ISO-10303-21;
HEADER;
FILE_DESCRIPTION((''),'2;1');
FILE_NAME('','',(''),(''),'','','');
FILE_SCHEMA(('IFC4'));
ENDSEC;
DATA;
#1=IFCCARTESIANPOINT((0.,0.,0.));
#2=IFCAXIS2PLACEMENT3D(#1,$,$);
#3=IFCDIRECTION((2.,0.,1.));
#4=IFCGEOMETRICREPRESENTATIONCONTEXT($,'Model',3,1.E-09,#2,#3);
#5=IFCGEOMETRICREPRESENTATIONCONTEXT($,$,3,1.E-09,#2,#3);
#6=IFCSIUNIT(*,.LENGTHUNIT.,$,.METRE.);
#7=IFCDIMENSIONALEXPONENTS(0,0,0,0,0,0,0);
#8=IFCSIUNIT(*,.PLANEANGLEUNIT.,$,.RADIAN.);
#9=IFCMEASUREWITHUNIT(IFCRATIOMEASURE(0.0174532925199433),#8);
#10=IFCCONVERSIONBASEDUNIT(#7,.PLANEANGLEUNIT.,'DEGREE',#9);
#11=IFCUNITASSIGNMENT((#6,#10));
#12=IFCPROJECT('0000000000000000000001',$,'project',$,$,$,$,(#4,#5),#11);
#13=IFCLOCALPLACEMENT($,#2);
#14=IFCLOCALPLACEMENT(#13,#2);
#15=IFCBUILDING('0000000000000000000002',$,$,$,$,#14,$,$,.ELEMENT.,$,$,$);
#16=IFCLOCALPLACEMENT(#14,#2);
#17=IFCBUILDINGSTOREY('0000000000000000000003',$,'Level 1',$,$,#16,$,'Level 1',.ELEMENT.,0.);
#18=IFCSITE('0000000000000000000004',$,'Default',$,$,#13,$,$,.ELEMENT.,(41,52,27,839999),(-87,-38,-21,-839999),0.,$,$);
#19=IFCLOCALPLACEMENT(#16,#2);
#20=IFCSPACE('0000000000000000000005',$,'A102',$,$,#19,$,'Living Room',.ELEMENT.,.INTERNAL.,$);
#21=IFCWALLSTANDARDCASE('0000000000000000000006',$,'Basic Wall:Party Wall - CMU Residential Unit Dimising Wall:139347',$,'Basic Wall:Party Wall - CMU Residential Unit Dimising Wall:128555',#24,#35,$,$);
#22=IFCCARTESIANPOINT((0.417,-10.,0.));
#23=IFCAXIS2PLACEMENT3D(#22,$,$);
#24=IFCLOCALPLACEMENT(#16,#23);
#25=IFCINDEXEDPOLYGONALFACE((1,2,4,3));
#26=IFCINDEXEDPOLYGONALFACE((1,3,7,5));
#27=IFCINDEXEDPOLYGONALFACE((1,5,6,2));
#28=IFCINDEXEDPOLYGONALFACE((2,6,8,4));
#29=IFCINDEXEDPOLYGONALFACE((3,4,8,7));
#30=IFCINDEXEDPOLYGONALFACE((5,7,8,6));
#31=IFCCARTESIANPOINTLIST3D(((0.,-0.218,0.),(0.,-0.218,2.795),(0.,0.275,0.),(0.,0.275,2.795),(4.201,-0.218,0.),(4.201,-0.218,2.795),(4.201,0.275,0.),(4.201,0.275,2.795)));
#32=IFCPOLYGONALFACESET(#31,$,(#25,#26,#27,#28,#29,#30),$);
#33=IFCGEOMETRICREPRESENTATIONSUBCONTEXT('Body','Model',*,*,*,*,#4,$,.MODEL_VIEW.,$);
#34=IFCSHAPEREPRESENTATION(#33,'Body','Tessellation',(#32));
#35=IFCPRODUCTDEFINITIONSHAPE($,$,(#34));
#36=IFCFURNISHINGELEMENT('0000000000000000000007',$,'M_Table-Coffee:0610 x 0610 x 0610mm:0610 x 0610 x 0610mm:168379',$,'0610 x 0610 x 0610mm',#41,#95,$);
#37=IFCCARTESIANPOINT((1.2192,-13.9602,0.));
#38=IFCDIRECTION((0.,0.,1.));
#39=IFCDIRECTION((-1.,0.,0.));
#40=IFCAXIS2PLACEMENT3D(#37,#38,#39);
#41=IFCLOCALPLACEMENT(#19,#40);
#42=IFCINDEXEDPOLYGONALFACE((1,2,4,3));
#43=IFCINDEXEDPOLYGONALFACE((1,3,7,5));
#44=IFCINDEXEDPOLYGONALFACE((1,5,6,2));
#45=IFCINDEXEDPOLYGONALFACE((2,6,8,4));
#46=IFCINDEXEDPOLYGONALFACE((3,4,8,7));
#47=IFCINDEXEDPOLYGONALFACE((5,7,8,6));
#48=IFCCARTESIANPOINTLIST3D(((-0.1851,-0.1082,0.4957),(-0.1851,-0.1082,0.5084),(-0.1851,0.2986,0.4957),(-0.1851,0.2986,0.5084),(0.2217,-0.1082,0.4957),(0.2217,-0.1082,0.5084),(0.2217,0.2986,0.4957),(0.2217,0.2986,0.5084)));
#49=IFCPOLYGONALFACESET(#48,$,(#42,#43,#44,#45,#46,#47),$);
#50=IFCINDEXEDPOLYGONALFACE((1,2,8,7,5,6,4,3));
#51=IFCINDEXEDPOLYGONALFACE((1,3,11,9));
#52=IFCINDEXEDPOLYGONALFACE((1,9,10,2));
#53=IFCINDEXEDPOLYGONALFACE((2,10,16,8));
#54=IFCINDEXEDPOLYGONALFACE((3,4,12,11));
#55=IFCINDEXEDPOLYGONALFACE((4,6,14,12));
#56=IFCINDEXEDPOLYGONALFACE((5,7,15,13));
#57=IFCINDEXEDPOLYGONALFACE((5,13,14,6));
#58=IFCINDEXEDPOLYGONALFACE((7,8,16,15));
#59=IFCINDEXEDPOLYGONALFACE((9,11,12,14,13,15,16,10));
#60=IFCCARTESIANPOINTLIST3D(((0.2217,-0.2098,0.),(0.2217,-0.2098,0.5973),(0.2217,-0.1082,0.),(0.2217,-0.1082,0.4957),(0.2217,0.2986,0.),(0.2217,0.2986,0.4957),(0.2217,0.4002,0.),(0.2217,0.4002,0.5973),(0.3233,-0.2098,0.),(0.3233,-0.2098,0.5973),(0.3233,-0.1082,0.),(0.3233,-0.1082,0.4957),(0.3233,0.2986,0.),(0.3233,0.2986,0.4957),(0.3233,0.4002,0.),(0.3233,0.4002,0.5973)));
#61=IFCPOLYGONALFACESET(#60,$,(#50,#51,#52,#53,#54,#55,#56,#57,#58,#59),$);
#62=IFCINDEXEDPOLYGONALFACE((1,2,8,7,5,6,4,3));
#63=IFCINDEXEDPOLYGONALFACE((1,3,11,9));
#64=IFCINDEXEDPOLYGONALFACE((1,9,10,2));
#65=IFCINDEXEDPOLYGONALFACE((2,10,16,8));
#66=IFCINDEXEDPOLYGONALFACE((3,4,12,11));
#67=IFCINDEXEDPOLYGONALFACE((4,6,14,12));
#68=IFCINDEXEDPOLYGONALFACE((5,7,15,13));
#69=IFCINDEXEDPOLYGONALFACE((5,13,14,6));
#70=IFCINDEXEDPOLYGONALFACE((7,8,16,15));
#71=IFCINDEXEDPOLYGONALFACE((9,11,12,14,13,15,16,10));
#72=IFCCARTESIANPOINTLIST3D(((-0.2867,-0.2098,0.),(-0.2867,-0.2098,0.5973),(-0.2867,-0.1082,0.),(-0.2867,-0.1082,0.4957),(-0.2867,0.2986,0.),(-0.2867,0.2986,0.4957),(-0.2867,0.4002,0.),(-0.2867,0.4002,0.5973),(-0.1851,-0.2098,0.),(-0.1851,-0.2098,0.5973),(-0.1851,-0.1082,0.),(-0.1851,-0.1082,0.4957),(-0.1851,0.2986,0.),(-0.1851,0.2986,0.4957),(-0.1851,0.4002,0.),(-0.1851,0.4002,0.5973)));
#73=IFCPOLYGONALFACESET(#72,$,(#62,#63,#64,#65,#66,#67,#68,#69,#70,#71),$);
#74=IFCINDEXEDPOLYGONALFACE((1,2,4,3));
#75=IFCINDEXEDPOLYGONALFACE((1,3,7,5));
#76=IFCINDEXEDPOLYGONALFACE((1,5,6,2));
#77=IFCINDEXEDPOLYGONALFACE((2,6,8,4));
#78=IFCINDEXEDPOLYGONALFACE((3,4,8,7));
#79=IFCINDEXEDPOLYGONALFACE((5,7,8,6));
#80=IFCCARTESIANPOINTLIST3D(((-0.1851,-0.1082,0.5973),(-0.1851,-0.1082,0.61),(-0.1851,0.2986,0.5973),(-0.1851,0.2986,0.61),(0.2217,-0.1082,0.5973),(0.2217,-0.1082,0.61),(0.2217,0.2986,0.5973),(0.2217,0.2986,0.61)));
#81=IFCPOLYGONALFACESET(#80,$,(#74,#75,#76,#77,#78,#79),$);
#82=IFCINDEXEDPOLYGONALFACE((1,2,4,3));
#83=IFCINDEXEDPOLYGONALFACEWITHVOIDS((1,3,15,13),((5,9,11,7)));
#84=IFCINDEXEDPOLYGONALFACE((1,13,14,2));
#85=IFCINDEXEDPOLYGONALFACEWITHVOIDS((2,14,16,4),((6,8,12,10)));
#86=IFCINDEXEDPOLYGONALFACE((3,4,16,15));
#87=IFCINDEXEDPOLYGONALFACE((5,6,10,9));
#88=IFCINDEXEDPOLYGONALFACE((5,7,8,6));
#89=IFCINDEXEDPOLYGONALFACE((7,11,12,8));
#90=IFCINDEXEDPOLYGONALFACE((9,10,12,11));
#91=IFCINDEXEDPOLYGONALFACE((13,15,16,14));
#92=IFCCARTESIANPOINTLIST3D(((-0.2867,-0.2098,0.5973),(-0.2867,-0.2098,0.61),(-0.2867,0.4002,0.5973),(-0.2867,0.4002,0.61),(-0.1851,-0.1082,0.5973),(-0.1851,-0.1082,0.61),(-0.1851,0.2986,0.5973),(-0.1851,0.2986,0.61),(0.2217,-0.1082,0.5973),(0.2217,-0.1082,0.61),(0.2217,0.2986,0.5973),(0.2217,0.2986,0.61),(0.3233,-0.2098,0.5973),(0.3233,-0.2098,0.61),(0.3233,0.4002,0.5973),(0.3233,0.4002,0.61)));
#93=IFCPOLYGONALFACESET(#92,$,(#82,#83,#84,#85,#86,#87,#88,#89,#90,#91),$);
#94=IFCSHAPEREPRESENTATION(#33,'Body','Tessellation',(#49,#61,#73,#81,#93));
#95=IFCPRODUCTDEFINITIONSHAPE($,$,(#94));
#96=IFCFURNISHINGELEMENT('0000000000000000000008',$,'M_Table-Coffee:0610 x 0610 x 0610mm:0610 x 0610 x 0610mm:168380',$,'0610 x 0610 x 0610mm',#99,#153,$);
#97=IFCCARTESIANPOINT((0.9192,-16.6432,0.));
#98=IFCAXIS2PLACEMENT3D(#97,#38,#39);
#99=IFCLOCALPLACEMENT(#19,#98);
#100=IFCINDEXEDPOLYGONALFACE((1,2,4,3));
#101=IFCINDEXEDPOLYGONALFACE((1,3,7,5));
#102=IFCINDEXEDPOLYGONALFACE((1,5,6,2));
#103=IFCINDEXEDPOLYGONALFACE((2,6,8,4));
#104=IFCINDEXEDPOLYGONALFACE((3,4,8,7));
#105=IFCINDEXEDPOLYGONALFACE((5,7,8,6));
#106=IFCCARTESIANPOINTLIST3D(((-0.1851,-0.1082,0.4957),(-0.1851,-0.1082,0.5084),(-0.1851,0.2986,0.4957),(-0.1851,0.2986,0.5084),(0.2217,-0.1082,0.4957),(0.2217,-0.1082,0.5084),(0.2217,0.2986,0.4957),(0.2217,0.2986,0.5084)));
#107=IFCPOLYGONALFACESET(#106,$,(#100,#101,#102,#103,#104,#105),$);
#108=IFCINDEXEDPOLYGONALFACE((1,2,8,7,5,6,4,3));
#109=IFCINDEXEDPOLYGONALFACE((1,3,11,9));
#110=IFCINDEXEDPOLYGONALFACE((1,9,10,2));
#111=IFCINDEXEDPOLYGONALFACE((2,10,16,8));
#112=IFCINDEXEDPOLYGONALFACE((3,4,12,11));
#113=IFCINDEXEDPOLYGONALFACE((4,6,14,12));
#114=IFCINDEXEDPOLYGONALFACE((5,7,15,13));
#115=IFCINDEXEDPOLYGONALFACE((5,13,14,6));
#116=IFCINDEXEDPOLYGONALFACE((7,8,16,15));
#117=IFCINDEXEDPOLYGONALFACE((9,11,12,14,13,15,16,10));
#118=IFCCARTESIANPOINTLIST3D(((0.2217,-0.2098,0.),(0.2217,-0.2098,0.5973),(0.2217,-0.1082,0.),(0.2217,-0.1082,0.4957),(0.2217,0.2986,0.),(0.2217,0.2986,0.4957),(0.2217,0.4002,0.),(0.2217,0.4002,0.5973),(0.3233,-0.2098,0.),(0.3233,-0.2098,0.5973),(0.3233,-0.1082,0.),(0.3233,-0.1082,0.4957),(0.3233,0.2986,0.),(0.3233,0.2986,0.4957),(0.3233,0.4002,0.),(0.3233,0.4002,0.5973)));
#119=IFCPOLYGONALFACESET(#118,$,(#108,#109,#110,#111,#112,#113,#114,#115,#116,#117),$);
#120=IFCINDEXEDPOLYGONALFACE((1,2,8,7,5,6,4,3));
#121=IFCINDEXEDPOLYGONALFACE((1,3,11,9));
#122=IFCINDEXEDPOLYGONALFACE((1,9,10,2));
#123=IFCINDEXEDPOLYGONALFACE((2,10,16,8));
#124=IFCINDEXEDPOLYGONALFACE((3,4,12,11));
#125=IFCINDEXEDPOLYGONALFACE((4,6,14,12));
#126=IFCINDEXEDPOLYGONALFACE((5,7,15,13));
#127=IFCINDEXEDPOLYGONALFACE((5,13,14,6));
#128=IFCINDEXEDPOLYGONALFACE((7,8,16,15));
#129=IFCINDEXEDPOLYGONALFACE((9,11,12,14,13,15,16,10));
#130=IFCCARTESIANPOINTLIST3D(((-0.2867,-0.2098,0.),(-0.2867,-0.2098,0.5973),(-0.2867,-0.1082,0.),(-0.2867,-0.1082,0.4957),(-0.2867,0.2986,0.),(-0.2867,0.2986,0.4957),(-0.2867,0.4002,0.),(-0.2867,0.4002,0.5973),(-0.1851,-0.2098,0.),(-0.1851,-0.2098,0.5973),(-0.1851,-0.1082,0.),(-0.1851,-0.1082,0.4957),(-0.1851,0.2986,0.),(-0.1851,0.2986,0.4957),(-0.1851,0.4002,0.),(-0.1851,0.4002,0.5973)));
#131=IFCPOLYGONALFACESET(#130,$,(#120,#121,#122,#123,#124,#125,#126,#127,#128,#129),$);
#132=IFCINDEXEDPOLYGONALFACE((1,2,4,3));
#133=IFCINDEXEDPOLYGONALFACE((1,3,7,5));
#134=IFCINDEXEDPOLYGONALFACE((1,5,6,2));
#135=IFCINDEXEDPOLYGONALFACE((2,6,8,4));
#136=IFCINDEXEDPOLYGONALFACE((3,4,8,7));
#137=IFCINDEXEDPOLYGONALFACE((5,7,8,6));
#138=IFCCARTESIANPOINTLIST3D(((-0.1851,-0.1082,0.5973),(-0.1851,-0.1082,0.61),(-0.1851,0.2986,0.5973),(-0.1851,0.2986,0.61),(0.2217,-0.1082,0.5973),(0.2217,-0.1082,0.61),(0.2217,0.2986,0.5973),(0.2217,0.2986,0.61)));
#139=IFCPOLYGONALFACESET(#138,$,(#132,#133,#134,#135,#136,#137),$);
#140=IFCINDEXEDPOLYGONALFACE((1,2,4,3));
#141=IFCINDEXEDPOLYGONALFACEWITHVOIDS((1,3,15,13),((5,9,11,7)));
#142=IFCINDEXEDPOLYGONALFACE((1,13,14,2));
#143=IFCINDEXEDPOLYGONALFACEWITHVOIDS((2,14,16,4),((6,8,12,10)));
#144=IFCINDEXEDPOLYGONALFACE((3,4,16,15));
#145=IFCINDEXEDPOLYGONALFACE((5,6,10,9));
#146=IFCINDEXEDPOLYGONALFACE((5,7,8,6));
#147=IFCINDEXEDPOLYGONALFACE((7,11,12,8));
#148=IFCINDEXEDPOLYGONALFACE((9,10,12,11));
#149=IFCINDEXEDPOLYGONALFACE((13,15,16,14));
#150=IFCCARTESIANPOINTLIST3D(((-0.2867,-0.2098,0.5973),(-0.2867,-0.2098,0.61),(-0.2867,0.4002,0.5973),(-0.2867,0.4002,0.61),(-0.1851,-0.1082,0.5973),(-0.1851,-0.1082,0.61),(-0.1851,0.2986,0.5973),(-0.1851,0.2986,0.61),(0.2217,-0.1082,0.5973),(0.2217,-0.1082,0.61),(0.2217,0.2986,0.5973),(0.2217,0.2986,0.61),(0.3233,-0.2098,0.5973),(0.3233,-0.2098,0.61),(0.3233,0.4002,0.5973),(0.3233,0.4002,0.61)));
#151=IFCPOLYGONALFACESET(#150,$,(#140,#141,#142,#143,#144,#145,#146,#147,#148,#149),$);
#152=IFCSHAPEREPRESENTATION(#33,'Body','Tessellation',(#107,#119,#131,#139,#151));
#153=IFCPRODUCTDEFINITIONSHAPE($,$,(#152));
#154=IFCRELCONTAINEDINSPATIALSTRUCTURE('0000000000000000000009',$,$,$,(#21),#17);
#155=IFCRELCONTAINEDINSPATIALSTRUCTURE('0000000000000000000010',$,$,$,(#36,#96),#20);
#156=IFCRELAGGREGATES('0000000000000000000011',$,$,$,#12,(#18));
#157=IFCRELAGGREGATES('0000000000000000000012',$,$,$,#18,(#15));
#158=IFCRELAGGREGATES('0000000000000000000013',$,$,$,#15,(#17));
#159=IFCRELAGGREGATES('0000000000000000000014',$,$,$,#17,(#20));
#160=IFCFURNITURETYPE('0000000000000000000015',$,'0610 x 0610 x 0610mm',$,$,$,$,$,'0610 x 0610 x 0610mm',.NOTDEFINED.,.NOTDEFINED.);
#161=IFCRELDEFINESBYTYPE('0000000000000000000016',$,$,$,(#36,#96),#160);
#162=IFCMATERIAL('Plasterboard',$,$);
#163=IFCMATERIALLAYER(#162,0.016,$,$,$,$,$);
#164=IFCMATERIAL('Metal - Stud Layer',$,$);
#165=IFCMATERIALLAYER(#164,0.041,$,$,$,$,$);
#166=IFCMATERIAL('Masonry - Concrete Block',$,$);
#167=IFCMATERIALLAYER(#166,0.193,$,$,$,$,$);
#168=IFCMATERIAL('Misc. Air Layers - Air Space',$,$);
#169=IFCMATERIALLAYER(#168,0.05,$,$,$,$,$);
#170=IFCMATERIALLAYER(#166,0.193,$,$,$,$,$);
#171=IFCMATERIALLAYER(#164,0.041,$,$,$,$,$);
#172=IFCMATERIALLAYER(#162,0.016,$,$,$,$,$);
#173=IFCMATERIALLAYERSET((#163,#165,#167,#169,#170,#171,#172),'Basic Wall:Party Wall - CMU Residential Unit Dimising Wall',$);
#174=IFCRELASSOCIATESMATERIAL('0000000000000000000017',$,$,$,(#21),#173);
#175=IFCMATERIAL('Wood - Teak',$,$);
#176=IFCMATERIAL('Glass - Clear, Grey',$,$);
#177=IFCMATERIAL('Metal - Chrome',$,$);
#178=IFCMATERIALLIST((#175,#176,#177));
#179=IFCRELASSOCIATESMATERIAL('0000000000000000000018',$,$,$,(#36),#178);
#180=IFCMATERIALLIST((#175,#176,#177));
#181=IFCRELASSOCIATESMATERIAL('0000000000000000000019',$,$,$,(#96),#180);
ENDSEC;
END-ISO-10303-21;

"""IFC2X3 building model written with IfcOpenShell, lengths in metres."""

from ifc_helpers import new_model, entity, si_unit, converted_unit, direction, frame, frame_2d, origin, origin_2d_with_axis, place, context, subcontext, project, spatial, polyline, rectangle, outline, extrude, clip, bounded_halfspace, source, transform, mapped, material, material_list, layer, layer_set, layer_usage, type_object, type_shapes, element, save


model = new_model("IFC2X3")

# Units and contexts
model_context = context("Model", 3, precision=1e-09, world=origin(), true_north=direction((2.0, 0.0, 1.0)))
context_of_model = context(None, 3, precision=1e-09, world=origin(), true_north=direction((2.0, 0.0, 1.0)))
body_context = subcontext(model_context, "Body", "Model", "MODEL_VIEW")
ifc_project = project(units=[si_unit("LENGTHUNIT", "METRE"), converted_unit("PLANEANGLEUNIT", "DEGREE", entity("IfcRatioMeasure", 0.0174532925199433), si_unit("PLANEANGLEUNIT", "RADIAN"), dimensions=[0, 0, 0, 0, 0, 0, 0])], contexts=[model_context, context_of_model])

# Site, building, storey
site_placement = place(None, origin())
site = spatial("IfcSite", under=ifc_project, at=site_placement, Name="Default", CompositionType="ELEMENT", RefLatitude=(41, 52, 27, 839999), RefLongitude=(-87, -38, -21, -839999), RefElevation=0.0)
building_placement = place(site_placement, origin())
building = spatial("IfcBuilding", under=site, at=building_placement, CompositionType="ELEMENT")
storey_placement = place(building_placement, origin())
storey = spatial("IfcBuildingStorey", under=building, at=storey_placement, Name="Level 1", LongName="Level 1", CompositionType="ELEMENT", Elevation=0.0)

# Shared definitions
ifc_material_1 = material(Name="Misc. Air Layers - Air Space")
ifc_material_2 = material(Name="Masonry - Concrete Block")
ifc_material_3 = material(Name="Metal - Stud Layer")
ifc_material_4 = material(Name="Plasterboard")

# Wall
ifc_layer_1 = layer(ifc_material_4, 0.016)
ifc_layer_2 = layer(ifc_material_3, 0.041)
ifc_layer_3 = layer(ifc_material_2, 0.193)
ifc_layer_4 = layer(ifc_material_1, 0.05)
ifc_layer_5 = layer(ifc_material_2, 0.193)
ifc_layer_6 = layer(ifc_material_3, 0.041)
ifc_layer_7 = layer(ifc_material_4, 0.016)
ifc_layer_set_1 = layer_set([ifc_layer_1, ifc_layer_2, ifc_layer_3, ifc_layer_4, ifc_layer_5, ifc_layer_6, ifc_layer_7], Name="Basic Wall:Party Wall - CMU Residential Unit Dimising Wall")
ifc_layer_usage_1 = layer_usage(ifc_layer_set_1, "AXIS2", "NEGATIVE", 0.275)
wall_1_placement = place(storey_placement, frame((0.417, -10.0, 0.0)))
element("IfcWallStandardCase", 1, at=wall_1_placement, inside=storey, material=ifc_layer_usage_1, Name="Basic Wall:Party Wall - CMU Residential Unit Dimising Wall:139347", ObjectType="Basic Wall:Party Wall - CMU Residential Unit Dimising Wall:128555", context=body_context, shape_type="Clipping", body=[
    clip(clip(extrude(rectangle(XDim=4.201, YDim=0.55, at=frame_2d((2.1005, 0.0), x_axis=(-1.0, 0.0))), origin(), (0.0, 0.0, 1.0), 2.795), bounded_halfspace(frame((0.0, -0.218, 0.0), z_axis=(0.0, 1.0, 0.0), x_axis=(-1.0, 0.0, 0.0)), True, frame((0.0, -0.218, 0.0), z_axis=(0.0, 1.0, 0.0), x_axis=(-1.0, 0.0, 0.0)), polyline([(0.0, 0.0), (0.0, 2.795), (-4.201, 2.795), (-4.201, 0.0), (0.0, 0.0)]))), bounded_halfspace(frame((4.201, 0.275, 0.0), z_axis=(-1.0, 0.0, 0.0), x_axis=(0.0, -1.0, 0.0)), True, frame((4.201, 0.275, 0.0), z_axis=(-1.0, 0.0, 0.0), x_axis=(0.0, -1.0, 0.0)), polyline([(0.0, 0.0), (0.493, 0.0), (0.493, 2.795), (0.0, 2.795), (0.0, 0.0)]))),
])

# Shared definitions
space_placement = place(storey_placement, origin())
space = spatial("IfcSpace", under=storey, at=space_placement, Name="A102", LongName="Living Room", CompositionType="ELEMENT", InteriorOrExteriorSpace="INTERNAL")

# Furnishing elements
ifc_material_5 = material(Name="Wood - Teak")
ifc_material_6 = material(Name="Glass - Clear, Grey")
ifc_material_7 = material(Name="Metal - Chrome")
ifc_material_list_1 = material_list([ifc_material_5, ifc_material_6, ifc_material_7])
furniture_type_1 = type_object("IfcFurnitureType", Name="0610 x 0610 x 0610mm", ElementType="0610 x 0610 x 0610mm", AssemblyPlace="NOTDEFINED")
shared_shape_1 = source(origin(), body_context, "Body", "SweptSolid", [
    extrude(rectangle(XDim=0.4068, YDim=0.4068, at=origin_2d_with_axis()), frame((0.0183, 0.0952, 0.4957), z_axis=(0.0, 0.0, 1.0), x_axis=(-1.0, 0.0, 0.0)), (0.0, 0.0, 1.0), 0.0127),
    extrude(outline(polyline([(-0.2732, -0.305), (0.324, -0.305), (0.324, 0.305), (-0.2732, 0.305), (-0.2732, 0.2034), (0.2225, 0.2034), (0.2225, -0.2034), (-0.2732, -0.2034), (-0.2732, -0.305)])), frame((0.2217, 0.0952, 0.2732), z_axis=(1.0, 0.0, 0.0), x_axis=(0.0, 0.0, 1.0)), (0.0, 0.0, 1.0), 0.1016),
    extrude(outline(polyline([(-0.305, -0.3241), (0.305, -0.3241), (0.305, 0.2733), (0.2034, 0.2733), (0.2034, -0.2224), (-0.2034, -0.2224), (-0.2034, 0.2733), (-0.305, 0.2733), (-0.305, -0.3241)])), frame((-0.2867, 0.0952, 0.2733), z_axis=(1.0, 0.0, 0.0), x_axis=(0.0, -1.0, 0.0)), (0.0, 0.0, 1.0), 0.1016),
    extrude(rectangle(XDim=0.4068, YDim=0.4068, at=origin_2d_with_axis()), frame((0.0183, 0.0952, 0.5973), z_axis=(0.0, 0.0, 1.0), x_axis=(-1.0, 0.0, 0.0)), (0.0, 0.0, 1.0), 0.0127),
    extrude(outline(polyline([(-0.305, -0.305), (0.305, -0.305), (0.305, 0.305), (-0.305, 0.305), (-0.305, -0.305)]), holes=[polyline([(-0.2034, -0.2034), (-0.2034, 0.2034), (0.2034, 0.2034), (0.2034, -0.2034), (-0.2034, -0.2034)])]), frame((0.0183, 0.0952, 0.5973), z_axis=(0.0, 0.0, 1.0), x_axis=(-1.0, 0.0, 0.0)), (0.0, 0.0, 1.0), 0.0127),
])
type_shapes(furniture_type_1, [shared_shape_1])
furnishing_1_placement = place(space_placement, frame((1.2192, -13.9602, 0.0), z_axis=(0.0, 0.0, 1.0), x_axis=(-1.0, 0.0, 0.0)))
element("IfcFurnishingElement", 2, at=furnishing_1_placement, inside=space, type_object=furniture_type_1, material=ifc_material_list_1, Name="M_Table-Coffee:0610 x 0610 x 0610mm:0610 x 0610 x 0610mm:168379", ObjectType="0610 x 0610 x 0610mm", context=body_context, shape_type="MappedRepresentation", body=[
    mapped(shared_shape_1, transform((0.0, 0.0, 0.0), scale=1.0)),
])
ifc_material_list_2 = material_list([ifc_material_5, ifc_material_6, ifc_material_7])
furnishing_2_placement = place(space_placement, frame((0.9192, -16.6432, 0.0), z_axis=(0.0, 0.0, 1.0), x_axis=(-1.0, 0.0, 0.0)))
element("IfcFurnishingElement", 3, at=furnishing_2_placement, inside=space, type_object=furniture_type_1, material=ifc_material_list_2, Name="M_Table-Coffee:0610 x 0610 x 0610mm:0610 x 0610 x 0610mm:168380", ObjectType="0610 x 0610 x 0610mm", context=body_context, shape_type="MappedRepresentation", body=[
    mapped(shared_shape_1, transform((0.0, 0.0, 0.0), scale=1.0)),
])

save(model, "model.ifc")
